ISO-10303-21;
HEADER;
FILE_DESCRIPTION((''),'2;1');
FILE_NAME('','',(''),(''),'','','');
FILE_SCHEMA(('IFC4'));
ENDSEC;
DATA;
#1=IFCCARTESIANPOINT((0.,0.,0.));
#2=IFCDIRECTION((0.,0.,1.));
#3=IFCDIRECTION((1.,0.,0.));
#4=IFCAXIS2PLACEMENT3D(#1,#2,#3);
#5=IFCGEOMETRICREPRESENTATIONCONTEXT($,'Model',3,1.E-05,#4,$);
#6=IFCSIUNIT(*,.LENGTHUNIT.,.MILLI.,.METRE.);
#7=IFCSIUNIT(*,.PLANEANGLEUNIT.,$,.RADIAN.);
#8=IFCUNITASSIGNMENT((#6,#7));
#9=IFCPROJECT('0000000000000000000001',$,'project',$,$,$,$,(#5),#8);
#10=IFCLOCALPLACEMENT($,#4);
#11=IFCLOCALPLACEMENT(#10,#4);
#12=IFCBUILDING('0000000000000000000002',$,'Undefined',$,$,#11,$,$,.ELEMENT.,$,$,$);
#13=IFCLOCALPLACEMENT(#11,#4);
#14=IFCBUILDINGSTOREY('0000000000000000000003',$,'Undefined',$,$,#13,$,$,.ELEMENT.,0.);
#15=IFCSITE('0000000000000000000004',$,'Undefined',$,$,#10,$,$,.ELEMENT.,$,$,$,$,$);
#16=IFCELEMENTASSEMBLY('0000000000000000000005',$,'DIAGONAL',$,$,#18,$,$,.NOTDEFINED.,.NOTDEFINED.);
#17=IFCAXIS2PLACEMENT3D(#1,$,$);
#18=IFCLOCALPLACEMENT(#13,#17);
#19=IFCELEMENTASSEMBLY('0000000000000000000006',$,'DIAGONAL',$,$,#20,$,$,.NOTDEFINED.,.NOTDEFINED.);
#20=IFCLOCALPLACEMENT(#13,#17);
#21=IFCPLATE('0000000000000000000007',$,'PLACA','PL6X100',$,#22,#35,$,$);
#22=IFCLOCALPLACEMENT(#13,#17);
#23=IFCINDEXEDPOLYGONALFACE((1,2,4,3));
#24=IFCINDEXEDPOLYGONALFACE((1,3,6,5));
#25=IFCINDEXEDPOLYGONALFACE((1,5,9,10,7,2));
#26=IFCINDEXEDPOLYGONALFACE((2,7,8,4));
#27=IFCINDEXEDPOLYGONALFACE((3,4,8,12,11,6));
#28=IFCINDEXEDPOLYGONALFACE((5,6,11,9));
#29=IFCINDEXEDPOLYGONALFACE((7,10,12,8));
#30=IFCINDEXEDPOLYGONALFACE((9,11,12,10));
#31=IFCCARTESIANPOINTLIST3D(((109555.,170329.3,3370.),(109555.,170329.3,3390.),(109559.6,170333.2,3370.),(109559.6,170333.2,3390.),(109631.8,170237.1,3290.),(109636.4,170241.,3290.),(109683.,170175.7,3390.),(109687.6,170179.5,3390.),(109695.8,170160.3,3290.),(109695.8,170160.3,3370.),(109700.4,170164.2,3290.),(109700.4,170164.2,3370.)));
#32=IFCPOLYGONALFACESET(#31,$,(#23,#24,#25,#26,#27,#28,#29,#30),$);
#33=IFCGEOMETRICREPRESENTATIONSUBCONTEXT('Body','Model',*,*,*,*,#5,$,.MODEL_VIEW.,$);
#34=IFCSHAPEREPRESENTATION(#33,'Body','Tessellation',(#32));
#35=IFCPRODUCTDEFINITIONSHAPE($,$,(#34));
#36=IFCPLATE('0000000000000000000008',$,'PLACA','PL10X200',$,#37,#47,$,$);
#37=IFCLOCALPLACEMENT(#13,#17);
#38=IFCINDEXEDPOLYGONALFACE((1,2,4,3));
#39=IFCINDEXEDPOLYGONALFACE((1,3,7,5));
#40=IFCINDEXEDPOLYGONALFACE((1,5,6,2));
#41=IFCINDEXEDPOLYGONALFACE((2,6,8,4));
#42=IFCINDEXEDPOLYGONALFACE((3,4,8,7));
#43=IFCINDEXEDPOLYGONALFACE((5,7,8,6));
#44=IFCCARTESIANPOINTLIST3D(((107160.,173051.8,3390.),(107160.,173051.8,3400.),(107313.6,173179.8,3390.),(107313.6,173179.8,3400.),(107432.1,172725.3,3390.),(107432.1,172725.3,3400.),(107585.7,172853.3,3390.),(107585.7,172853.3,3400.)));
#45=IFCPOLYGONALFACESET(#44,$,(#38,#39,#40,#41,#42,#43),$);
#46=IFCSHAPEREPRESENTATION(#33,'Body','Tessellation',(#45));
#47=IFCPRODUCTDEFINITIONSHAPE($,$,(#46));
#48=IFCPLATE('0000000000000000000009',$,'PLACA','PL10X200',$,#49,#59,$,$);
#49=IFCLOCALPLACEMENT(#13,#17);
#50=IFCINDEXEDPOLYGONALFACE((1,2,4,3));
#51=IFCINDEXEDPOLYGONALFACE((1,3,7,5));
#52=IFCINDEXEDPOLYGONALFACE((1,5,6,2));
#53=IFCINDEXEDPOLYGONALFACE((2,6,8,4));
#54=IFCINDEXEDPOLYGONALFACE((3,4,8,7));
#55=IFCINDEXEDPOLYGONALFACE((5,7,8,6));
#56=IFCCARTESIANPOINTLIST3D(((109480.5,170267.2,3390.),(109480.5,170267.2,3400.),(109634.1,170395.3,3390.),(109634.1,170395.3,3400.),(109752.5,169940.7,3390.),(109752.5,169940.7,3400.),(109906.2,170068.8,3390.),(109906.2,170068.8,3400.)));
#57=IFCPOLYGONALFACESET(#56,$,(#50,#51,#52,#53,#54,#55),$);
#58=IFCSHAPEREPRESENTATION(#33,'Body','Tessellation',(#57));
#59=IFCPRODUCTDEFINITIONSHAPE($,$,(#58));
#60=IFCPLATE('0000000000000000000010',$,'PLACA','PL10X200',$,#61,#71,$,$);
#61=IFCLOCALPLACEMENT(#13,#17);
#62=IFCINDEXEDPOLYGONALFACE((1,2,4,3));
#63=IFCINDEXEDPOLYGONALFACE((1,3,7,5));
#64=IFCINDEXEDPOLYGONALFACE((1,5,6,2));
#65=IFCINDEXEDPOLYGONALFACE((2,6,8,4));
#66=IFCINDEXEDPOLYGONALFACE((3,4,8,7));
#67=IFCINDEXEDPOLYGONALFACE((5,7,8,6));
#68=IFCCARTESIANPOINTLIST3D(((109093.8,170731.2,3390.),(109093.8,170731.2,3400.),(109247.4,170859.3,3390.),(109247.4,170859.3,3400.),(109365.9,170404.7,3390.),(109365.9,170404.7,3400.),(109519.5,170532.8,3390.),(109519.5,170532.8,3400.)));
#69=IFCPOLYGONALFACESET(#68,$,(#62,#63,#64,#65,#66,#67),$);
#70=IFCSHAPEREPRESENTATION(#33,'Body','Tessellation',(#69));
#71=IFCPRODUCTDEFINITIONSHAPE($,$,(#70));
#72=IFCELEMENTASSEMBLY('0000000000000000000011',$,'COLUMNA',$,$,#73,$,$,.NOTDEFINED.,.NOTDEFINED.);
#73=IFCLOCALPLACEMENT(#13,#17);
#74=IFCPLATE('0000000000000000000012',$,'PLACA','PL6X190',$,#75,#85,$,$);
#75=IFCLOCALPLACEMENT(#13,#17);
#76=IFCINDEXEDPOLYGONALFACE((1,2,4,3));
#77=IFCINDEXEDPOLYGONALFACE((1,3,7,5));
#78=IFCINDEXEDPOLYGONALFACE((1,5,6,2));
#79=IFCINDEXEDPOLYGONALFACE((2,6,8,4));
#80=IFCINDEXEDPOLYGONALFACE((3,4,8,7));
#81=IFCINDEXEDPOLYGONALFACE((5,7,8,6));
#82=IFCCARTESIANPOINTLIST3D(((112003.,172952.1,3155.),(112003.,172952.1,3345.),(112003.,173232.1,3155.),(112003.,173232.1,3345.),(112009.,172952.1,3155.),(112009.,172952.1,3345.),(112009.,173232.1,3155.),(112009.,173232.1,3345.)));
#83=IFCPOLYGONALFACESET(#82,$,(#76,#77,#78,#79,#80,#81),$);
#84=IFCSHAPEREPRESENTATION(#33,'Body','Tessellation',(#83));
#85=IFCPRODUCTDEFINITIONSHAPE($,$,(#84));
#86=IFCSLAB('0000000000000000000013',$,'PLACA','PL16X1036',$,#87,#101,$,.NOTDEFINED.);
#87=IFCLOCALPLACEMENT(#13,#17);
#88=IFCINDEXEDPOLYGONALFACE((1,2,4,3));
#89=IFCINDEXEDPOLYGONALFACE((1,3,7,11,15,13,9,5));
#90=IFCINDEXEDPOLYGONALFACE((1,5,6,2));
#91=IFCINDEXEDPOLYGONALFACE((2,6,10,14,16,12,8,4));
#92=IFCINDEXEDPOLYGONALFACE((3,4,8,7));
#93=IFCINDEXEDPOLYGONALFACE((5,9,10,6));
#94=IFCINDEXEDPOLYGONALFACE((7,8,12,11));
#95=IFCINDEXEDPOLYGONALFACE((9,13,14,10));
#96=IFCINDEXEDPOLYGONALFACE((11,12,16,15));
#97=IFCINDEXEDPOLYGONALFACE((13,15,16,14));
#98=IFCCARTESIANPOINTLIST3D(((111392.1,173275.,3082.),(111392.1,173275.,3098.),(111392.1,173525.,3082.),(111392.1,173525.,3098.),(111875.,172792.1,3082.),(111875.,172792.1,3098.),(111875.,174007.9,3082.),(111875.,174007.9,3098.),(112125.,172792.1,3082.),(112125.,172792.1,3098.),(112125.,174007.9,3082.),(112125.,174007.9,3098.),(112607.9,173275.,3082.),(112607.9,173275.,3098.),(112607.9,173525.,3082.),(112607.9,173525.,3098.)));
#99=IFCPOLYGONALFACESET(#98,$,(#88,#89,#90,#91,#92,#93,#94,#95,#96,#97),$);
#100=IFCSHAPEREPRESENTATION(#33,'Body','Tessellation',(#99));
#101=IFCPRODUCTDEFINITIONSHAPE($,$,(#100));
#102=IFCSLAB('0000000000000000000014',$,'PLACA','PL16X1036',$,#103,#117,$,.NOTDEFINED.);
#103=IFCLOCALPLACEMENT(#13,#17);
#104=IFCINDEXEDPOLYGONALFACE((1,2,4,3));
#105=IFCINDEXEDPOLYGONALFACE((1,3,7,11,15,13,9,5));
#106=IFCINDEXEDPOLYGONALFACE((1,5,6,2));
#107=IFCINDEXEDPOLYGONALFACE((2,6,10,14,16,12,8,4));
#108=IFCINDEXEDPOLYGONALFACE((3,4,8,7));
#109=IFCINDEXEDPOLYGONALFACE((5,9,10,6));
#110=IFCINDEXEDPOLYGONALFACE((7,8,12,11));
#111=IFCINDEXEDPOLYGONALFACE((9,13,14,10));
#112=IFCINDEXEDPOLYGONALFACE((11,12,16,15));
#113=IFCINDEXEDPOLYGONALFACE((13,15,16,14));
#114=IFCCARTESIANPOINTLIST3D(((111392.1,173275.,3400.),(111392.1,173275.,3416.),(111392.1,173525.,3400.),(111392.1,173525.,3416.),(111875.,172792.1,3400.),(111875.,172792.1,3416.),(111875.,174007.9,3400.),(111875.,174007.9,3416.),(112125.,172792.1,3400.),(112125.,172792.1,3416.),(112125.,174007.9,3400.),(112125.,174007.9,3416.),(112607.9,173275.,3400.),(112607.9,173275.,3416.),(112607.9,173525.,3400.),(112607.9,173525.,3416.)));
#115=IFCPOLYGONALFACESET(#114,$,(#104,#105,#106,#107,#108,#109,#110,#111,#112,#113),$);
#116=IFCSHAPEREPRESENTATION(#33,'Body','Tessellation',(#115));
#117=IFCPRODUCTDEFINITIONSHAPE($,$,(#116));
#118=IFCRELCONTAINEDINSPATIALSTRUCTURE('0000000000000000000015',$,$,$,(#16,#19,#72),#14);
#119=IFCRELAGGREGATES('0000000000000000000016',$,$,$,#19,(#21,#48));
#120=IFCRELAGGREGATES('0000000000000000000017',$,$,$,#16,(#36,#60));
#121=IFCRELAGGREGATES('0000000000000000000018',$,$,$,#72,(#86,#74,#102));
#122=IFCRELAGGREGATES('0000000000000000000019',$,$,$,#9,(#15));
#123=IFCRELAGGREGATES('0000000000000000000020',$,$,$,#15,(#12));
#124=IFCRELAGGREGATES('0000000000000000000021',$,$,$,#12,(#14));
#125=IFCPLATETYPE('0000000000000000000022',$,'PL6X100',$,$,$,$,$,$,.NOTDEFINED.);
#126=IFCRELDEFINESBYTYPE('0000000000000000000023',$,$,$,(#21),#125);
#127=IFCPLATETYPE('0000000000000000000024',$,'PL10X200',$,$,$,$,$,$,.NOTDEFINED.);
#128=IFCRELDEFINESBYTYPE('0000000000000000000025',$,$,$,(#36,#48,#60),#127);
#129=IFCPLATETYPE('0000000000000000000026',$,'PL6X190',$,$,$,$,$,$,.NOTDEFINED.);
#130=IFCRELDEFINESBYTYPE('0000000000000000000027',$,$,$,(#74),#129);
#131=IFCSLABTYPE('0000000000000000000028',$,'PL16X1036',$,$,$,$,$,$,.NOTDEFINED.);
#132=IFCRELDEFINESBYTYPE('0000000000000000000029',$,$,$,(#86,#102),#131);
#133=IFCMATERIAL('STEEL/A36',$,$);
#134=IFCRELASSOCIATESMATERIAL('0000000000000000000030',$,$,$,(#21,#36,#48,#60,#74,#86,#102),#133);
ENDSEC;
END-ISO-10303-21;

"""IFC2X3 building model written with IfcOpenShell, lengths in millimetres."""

from ifc_helpers import new_model, si_unit, frame, origin_with_axes, place, context, subcontext, project, spatial, polyline, outline, extrude, material, type_object, element, aggregate, save


model = new_model("IFC2X3")

# Units and contexts
model_context = context("Model", 3, precision=1e-05, world=origin_with_axes())
body_context = subcontext(model_context, "Body", "Model", "MODEL_VIEW")
ifc_project = project(units=[si_unit("LENGTHUNIT", "METRE", prefix="MILLI"), si_unit("PLANEANGLEUNIT", "RADIAN")], contexts=[model_context])

# Site, building, storey
site_placement = place(None, origin_with_axes())
site = spatial("IfcSite", under=ifc_project, at=site_placement, Name="Undefined", CompositionType="ELEMENT")
building_placement = place(site_placement, origin_with_axes())
building = spatial("IfcBuilding", under=site, at=building_placement, Name="Undefined", CompositionType="ELEMENT")
storey_placement = place(building_placement, origin_with_axes())
storey = spatial("IfcBuildingStorey", under=building, at=storey_placement, Name="Undefined", CompositionType="ELEMENT", Elevation=0.0)

# Shared definitions
ifc_material_1 = material(Name="STEEL/A36")

# Element assembly
assembly_1_placement = place(storey_placement, origin_with_axes())
assembly_1 = element("IfcElementAssembly", 1, at=assembly_1_placement, inside=storey, Name="DIAGONAL", AssemblyPlace="NOTDEFINED", PredefinedType="NOTDEFINED")

# Element assembly
assembly_2_placement = place(storey_placement, origin_with_axes())
assembly_2 = element("IfcElementAssembly", 2, at=assembly_2_placement, inside=storey, Name="DIAGONAL", AssemblyPlace="NOTDEFINED", PredefinedType="NOTDEFINED")

# Plates
plate_type_1 = type_object("IfcPlateType", Name="PL6X100", PredefinedType="NOTDEFINED")
plate_1_placement = place(assembly_2_placement, frame((109557.3, 170331.2, 3290.0), z_axis=(-0.768221, -0.640185, 0.0), x_axis=(0.640185, -0.768221, 0.0)))
plate_1 = element("IfcPlate", 3, at=plate_1_placement, type_object=plate_type_1, material=ifc_material_1, Name="PLACA", Description="PL6X100", context=body_context, shape_type="SweptSolid", body=[
    extrude(outline(polyline([(0.0, 80.0), (120.0, 0.0), (220.0, 0.0), (220.0, 80.0), (200.0, 100.0), (0.0, 100.0), (0.0, 80.0)])), frame((0.0, 0.0, -3.0), z_axis=(0.0, 0.0, 1.0), x_axis=(1.0, 0.0, 0.0)), (0.0, 0.0, 1.0), 6.0),
])
plate_type_2 = type_object("IfcPlateType", Name="PL10X200", PredefinedType="NOTDEFINED")
plate_2_placement = place(assembly_1_placement, frame((107236.8, 173115.8, 3395.0), z_axis=(0.0, 0.0, 1.0), x_axis=(0.640185, -0.768221, 0.0)))
plate_2 = element("IfcPlate", 4, at=plate_2_placement, type_object=plate_type_2, material=ifc_material_1, Name="PLACA", Description="PL10X200", context=body_context, shape_type="SweptSolid", body=[
    extrude(outline(polyline([(0.0, -100.0), (0.0, 100.0), (425.0, 100.0), (425.0, -100.0), (0.0, -100.0)])), frame((0.0, 0.0, -5.0), z_axis=(0.0, 0.0, 1.0), x_axis=(1.0, 0.0, 0.0)), (0.0, 0.0, 1.0), 10.0),
])
plate_3_placement = place(assembly_2_placement, frame((109557.3, 170331.2, 3395.0), z_axis=(0.0, 0.0, 1.0), x_axis=(0.640185, -0.768221, 0.0)))
plate_3 = element("IfcPlate", 5, at=plate_3_placement, type_object=plate_type_2, material=ifc_material_1, Name="PLACA", Description="PL10X200", context=body_context, shape_type="SweptSolid", body=[
    extrude(outline(polyline([(0.0, -100.0), (0.0, 100.0), (425.0, 100.0), (425.0, -100.0), (0.0, -100.0)])), frame((0.0, 0.0, -5.0), z_axis=(0.0, 0.0, 1.0), x_axis=(1.0, 0.0, 0.0)), (0.0, 0.0, 1.0), 10.0),
])
plate_4_placement = place(assembly_1_placement, frame((109442.7, 170468.8, 3395.0), z_axis=(0.0, 0.0, 1.0), x_axis=(-0.640185, 0.768221, 0.0)))
plate_4 = element("IfcPlate", 6, at=plate_4_placement, type_object=plate_type_2, material=ifc_material_1, Name="PLACA", Description="PL10X200", context=body_context, shape_type="SweptSolid", body=[
    extrude(outline(polyline([(0.0, -100.0), (0.0, 100.0), (425.0, 100.0), (425.0, -100.0), (0.0, -100.0)])), frame((0.0, 0.0, -5.0), z_axis=(0.0, 0.0, 1.0), x_axis=(1.0, 0.0, 0.0)), (0.0, 0.0, 1.0), 10.0),
])

# Element assembly, plate
assembly_3_placement = place(storey_placement, origin_with_axes())
assembly_3 = element("IfcElementAssembly", 7, at=assembly_3_placement, inside=storey, Name="COLUMNA", AssemblyPlace="NOTDEFINED", PredefinedType="NOTDEFINED")
plate_type_3 = type_object("IfcPlateType", Name="PL6X190", PredefinedType="NOTDEFINED")
plate_5_placement = place(assembly_3_placement, frame((112006.0, 172952.1, 3250.0), z_axis=(1.0, 0.0, 0.0), x_axis=(0.0, 1.0, 0.0)))
plate_5 = element("IfcPlate", 8, at=plate_5_placement, type_object=plate_type_3, material=ifc_material_1, Name="PLACA", Description="PL6X190", context=body_context, shape_type="SweptSolid", body=[
    extrude(outline(polyline([(0.0, -95.0), (0.0, 95.0), (280.0, 95.0), (280.0, -95.0), (0.0, -95.0)])), frame((0.0, 0.0, -3.0), z_axis=(0.0, 0.0, 1.0), x_axis=(1.0, 0.0, 0.0)), (0.0, 0.0, 1.0), 6.0),
])

# Slabs
slab_type = type_object("IfcSlabType", Name="PL16X1036", PredefinedType="NOTDEFINED")
slab_1_placement = place(assembly_3_placement, frame((112125.0, 172792.1, 3090.0), z_axis=(0.0, 0.0, 1.0), x_axis=(0.707107, 0.707107, 0.0)))
slab_1 = element("IfcSlab", 9, at=slab_1_placement, type_object=slab_type, material=ifc_material_1, Name="PLACA", Description="PL16X1036", PredefinedType="NOTDEFINED", context=body_context, shape_type="SweptSolid", body=[
    extrude(outline(polyline([(0.0, 0.0), (682.9, 0.0), (859.7, 176.8), (859.7, 859.7), (682.9, 1036.5), (0.0, 1036.5), (-176.8, 859.7), (-176.8, 176.8), (0.0, 0.0)])), frame((0.0, 0.0, -8.0), z_axis=(0.0, 0.0, 1.0), x_axis=(1.0, 0.0, 0.0)), (0.0, 0.0, 1.0), 16.0),
])
slab_2_placement = place(assembly_3_placement, frame((112125.0, 172792.1, 3408.0), z_axis=(0.0, 0.0, 1.0), x_axis=(0.707107, 0.707107, 0.0)))
slab_2 = element("IfcSlab", 10, at=slab_2_placement, type_object=slab_type, material=ifc_material_1, Name="PLACA", Description="PL16X1036", PredefinedType="NOTDEFINED", context=body_context, shape_type="SweptSolid", body=[
    extrude(outline(polyline([(0.0, 0.0), (682.9, 0.0), (859.7, 176.8), (859.7, 859.7), (682.9, 1036.5), (0.0, 1036.5), (-176.8, 859.7), (-176.8, 176.8), (0.0, 0.0)])), frame((0.0, 0.0, -8.0), z_axis=(0.0, 0.0, 1.0), x_axis=(1.0, 0.0, 0.0)), (0.0, 0.0, 1.0), 16.0),
])

aggregate(assembly_2, [plate_1, plate_3])
aggregate(assembly_1, [plate_2, plate_4])

aggregate(assembly_3, [slab_1, plate_5, slab_2])

save(model, "model.ifc")
